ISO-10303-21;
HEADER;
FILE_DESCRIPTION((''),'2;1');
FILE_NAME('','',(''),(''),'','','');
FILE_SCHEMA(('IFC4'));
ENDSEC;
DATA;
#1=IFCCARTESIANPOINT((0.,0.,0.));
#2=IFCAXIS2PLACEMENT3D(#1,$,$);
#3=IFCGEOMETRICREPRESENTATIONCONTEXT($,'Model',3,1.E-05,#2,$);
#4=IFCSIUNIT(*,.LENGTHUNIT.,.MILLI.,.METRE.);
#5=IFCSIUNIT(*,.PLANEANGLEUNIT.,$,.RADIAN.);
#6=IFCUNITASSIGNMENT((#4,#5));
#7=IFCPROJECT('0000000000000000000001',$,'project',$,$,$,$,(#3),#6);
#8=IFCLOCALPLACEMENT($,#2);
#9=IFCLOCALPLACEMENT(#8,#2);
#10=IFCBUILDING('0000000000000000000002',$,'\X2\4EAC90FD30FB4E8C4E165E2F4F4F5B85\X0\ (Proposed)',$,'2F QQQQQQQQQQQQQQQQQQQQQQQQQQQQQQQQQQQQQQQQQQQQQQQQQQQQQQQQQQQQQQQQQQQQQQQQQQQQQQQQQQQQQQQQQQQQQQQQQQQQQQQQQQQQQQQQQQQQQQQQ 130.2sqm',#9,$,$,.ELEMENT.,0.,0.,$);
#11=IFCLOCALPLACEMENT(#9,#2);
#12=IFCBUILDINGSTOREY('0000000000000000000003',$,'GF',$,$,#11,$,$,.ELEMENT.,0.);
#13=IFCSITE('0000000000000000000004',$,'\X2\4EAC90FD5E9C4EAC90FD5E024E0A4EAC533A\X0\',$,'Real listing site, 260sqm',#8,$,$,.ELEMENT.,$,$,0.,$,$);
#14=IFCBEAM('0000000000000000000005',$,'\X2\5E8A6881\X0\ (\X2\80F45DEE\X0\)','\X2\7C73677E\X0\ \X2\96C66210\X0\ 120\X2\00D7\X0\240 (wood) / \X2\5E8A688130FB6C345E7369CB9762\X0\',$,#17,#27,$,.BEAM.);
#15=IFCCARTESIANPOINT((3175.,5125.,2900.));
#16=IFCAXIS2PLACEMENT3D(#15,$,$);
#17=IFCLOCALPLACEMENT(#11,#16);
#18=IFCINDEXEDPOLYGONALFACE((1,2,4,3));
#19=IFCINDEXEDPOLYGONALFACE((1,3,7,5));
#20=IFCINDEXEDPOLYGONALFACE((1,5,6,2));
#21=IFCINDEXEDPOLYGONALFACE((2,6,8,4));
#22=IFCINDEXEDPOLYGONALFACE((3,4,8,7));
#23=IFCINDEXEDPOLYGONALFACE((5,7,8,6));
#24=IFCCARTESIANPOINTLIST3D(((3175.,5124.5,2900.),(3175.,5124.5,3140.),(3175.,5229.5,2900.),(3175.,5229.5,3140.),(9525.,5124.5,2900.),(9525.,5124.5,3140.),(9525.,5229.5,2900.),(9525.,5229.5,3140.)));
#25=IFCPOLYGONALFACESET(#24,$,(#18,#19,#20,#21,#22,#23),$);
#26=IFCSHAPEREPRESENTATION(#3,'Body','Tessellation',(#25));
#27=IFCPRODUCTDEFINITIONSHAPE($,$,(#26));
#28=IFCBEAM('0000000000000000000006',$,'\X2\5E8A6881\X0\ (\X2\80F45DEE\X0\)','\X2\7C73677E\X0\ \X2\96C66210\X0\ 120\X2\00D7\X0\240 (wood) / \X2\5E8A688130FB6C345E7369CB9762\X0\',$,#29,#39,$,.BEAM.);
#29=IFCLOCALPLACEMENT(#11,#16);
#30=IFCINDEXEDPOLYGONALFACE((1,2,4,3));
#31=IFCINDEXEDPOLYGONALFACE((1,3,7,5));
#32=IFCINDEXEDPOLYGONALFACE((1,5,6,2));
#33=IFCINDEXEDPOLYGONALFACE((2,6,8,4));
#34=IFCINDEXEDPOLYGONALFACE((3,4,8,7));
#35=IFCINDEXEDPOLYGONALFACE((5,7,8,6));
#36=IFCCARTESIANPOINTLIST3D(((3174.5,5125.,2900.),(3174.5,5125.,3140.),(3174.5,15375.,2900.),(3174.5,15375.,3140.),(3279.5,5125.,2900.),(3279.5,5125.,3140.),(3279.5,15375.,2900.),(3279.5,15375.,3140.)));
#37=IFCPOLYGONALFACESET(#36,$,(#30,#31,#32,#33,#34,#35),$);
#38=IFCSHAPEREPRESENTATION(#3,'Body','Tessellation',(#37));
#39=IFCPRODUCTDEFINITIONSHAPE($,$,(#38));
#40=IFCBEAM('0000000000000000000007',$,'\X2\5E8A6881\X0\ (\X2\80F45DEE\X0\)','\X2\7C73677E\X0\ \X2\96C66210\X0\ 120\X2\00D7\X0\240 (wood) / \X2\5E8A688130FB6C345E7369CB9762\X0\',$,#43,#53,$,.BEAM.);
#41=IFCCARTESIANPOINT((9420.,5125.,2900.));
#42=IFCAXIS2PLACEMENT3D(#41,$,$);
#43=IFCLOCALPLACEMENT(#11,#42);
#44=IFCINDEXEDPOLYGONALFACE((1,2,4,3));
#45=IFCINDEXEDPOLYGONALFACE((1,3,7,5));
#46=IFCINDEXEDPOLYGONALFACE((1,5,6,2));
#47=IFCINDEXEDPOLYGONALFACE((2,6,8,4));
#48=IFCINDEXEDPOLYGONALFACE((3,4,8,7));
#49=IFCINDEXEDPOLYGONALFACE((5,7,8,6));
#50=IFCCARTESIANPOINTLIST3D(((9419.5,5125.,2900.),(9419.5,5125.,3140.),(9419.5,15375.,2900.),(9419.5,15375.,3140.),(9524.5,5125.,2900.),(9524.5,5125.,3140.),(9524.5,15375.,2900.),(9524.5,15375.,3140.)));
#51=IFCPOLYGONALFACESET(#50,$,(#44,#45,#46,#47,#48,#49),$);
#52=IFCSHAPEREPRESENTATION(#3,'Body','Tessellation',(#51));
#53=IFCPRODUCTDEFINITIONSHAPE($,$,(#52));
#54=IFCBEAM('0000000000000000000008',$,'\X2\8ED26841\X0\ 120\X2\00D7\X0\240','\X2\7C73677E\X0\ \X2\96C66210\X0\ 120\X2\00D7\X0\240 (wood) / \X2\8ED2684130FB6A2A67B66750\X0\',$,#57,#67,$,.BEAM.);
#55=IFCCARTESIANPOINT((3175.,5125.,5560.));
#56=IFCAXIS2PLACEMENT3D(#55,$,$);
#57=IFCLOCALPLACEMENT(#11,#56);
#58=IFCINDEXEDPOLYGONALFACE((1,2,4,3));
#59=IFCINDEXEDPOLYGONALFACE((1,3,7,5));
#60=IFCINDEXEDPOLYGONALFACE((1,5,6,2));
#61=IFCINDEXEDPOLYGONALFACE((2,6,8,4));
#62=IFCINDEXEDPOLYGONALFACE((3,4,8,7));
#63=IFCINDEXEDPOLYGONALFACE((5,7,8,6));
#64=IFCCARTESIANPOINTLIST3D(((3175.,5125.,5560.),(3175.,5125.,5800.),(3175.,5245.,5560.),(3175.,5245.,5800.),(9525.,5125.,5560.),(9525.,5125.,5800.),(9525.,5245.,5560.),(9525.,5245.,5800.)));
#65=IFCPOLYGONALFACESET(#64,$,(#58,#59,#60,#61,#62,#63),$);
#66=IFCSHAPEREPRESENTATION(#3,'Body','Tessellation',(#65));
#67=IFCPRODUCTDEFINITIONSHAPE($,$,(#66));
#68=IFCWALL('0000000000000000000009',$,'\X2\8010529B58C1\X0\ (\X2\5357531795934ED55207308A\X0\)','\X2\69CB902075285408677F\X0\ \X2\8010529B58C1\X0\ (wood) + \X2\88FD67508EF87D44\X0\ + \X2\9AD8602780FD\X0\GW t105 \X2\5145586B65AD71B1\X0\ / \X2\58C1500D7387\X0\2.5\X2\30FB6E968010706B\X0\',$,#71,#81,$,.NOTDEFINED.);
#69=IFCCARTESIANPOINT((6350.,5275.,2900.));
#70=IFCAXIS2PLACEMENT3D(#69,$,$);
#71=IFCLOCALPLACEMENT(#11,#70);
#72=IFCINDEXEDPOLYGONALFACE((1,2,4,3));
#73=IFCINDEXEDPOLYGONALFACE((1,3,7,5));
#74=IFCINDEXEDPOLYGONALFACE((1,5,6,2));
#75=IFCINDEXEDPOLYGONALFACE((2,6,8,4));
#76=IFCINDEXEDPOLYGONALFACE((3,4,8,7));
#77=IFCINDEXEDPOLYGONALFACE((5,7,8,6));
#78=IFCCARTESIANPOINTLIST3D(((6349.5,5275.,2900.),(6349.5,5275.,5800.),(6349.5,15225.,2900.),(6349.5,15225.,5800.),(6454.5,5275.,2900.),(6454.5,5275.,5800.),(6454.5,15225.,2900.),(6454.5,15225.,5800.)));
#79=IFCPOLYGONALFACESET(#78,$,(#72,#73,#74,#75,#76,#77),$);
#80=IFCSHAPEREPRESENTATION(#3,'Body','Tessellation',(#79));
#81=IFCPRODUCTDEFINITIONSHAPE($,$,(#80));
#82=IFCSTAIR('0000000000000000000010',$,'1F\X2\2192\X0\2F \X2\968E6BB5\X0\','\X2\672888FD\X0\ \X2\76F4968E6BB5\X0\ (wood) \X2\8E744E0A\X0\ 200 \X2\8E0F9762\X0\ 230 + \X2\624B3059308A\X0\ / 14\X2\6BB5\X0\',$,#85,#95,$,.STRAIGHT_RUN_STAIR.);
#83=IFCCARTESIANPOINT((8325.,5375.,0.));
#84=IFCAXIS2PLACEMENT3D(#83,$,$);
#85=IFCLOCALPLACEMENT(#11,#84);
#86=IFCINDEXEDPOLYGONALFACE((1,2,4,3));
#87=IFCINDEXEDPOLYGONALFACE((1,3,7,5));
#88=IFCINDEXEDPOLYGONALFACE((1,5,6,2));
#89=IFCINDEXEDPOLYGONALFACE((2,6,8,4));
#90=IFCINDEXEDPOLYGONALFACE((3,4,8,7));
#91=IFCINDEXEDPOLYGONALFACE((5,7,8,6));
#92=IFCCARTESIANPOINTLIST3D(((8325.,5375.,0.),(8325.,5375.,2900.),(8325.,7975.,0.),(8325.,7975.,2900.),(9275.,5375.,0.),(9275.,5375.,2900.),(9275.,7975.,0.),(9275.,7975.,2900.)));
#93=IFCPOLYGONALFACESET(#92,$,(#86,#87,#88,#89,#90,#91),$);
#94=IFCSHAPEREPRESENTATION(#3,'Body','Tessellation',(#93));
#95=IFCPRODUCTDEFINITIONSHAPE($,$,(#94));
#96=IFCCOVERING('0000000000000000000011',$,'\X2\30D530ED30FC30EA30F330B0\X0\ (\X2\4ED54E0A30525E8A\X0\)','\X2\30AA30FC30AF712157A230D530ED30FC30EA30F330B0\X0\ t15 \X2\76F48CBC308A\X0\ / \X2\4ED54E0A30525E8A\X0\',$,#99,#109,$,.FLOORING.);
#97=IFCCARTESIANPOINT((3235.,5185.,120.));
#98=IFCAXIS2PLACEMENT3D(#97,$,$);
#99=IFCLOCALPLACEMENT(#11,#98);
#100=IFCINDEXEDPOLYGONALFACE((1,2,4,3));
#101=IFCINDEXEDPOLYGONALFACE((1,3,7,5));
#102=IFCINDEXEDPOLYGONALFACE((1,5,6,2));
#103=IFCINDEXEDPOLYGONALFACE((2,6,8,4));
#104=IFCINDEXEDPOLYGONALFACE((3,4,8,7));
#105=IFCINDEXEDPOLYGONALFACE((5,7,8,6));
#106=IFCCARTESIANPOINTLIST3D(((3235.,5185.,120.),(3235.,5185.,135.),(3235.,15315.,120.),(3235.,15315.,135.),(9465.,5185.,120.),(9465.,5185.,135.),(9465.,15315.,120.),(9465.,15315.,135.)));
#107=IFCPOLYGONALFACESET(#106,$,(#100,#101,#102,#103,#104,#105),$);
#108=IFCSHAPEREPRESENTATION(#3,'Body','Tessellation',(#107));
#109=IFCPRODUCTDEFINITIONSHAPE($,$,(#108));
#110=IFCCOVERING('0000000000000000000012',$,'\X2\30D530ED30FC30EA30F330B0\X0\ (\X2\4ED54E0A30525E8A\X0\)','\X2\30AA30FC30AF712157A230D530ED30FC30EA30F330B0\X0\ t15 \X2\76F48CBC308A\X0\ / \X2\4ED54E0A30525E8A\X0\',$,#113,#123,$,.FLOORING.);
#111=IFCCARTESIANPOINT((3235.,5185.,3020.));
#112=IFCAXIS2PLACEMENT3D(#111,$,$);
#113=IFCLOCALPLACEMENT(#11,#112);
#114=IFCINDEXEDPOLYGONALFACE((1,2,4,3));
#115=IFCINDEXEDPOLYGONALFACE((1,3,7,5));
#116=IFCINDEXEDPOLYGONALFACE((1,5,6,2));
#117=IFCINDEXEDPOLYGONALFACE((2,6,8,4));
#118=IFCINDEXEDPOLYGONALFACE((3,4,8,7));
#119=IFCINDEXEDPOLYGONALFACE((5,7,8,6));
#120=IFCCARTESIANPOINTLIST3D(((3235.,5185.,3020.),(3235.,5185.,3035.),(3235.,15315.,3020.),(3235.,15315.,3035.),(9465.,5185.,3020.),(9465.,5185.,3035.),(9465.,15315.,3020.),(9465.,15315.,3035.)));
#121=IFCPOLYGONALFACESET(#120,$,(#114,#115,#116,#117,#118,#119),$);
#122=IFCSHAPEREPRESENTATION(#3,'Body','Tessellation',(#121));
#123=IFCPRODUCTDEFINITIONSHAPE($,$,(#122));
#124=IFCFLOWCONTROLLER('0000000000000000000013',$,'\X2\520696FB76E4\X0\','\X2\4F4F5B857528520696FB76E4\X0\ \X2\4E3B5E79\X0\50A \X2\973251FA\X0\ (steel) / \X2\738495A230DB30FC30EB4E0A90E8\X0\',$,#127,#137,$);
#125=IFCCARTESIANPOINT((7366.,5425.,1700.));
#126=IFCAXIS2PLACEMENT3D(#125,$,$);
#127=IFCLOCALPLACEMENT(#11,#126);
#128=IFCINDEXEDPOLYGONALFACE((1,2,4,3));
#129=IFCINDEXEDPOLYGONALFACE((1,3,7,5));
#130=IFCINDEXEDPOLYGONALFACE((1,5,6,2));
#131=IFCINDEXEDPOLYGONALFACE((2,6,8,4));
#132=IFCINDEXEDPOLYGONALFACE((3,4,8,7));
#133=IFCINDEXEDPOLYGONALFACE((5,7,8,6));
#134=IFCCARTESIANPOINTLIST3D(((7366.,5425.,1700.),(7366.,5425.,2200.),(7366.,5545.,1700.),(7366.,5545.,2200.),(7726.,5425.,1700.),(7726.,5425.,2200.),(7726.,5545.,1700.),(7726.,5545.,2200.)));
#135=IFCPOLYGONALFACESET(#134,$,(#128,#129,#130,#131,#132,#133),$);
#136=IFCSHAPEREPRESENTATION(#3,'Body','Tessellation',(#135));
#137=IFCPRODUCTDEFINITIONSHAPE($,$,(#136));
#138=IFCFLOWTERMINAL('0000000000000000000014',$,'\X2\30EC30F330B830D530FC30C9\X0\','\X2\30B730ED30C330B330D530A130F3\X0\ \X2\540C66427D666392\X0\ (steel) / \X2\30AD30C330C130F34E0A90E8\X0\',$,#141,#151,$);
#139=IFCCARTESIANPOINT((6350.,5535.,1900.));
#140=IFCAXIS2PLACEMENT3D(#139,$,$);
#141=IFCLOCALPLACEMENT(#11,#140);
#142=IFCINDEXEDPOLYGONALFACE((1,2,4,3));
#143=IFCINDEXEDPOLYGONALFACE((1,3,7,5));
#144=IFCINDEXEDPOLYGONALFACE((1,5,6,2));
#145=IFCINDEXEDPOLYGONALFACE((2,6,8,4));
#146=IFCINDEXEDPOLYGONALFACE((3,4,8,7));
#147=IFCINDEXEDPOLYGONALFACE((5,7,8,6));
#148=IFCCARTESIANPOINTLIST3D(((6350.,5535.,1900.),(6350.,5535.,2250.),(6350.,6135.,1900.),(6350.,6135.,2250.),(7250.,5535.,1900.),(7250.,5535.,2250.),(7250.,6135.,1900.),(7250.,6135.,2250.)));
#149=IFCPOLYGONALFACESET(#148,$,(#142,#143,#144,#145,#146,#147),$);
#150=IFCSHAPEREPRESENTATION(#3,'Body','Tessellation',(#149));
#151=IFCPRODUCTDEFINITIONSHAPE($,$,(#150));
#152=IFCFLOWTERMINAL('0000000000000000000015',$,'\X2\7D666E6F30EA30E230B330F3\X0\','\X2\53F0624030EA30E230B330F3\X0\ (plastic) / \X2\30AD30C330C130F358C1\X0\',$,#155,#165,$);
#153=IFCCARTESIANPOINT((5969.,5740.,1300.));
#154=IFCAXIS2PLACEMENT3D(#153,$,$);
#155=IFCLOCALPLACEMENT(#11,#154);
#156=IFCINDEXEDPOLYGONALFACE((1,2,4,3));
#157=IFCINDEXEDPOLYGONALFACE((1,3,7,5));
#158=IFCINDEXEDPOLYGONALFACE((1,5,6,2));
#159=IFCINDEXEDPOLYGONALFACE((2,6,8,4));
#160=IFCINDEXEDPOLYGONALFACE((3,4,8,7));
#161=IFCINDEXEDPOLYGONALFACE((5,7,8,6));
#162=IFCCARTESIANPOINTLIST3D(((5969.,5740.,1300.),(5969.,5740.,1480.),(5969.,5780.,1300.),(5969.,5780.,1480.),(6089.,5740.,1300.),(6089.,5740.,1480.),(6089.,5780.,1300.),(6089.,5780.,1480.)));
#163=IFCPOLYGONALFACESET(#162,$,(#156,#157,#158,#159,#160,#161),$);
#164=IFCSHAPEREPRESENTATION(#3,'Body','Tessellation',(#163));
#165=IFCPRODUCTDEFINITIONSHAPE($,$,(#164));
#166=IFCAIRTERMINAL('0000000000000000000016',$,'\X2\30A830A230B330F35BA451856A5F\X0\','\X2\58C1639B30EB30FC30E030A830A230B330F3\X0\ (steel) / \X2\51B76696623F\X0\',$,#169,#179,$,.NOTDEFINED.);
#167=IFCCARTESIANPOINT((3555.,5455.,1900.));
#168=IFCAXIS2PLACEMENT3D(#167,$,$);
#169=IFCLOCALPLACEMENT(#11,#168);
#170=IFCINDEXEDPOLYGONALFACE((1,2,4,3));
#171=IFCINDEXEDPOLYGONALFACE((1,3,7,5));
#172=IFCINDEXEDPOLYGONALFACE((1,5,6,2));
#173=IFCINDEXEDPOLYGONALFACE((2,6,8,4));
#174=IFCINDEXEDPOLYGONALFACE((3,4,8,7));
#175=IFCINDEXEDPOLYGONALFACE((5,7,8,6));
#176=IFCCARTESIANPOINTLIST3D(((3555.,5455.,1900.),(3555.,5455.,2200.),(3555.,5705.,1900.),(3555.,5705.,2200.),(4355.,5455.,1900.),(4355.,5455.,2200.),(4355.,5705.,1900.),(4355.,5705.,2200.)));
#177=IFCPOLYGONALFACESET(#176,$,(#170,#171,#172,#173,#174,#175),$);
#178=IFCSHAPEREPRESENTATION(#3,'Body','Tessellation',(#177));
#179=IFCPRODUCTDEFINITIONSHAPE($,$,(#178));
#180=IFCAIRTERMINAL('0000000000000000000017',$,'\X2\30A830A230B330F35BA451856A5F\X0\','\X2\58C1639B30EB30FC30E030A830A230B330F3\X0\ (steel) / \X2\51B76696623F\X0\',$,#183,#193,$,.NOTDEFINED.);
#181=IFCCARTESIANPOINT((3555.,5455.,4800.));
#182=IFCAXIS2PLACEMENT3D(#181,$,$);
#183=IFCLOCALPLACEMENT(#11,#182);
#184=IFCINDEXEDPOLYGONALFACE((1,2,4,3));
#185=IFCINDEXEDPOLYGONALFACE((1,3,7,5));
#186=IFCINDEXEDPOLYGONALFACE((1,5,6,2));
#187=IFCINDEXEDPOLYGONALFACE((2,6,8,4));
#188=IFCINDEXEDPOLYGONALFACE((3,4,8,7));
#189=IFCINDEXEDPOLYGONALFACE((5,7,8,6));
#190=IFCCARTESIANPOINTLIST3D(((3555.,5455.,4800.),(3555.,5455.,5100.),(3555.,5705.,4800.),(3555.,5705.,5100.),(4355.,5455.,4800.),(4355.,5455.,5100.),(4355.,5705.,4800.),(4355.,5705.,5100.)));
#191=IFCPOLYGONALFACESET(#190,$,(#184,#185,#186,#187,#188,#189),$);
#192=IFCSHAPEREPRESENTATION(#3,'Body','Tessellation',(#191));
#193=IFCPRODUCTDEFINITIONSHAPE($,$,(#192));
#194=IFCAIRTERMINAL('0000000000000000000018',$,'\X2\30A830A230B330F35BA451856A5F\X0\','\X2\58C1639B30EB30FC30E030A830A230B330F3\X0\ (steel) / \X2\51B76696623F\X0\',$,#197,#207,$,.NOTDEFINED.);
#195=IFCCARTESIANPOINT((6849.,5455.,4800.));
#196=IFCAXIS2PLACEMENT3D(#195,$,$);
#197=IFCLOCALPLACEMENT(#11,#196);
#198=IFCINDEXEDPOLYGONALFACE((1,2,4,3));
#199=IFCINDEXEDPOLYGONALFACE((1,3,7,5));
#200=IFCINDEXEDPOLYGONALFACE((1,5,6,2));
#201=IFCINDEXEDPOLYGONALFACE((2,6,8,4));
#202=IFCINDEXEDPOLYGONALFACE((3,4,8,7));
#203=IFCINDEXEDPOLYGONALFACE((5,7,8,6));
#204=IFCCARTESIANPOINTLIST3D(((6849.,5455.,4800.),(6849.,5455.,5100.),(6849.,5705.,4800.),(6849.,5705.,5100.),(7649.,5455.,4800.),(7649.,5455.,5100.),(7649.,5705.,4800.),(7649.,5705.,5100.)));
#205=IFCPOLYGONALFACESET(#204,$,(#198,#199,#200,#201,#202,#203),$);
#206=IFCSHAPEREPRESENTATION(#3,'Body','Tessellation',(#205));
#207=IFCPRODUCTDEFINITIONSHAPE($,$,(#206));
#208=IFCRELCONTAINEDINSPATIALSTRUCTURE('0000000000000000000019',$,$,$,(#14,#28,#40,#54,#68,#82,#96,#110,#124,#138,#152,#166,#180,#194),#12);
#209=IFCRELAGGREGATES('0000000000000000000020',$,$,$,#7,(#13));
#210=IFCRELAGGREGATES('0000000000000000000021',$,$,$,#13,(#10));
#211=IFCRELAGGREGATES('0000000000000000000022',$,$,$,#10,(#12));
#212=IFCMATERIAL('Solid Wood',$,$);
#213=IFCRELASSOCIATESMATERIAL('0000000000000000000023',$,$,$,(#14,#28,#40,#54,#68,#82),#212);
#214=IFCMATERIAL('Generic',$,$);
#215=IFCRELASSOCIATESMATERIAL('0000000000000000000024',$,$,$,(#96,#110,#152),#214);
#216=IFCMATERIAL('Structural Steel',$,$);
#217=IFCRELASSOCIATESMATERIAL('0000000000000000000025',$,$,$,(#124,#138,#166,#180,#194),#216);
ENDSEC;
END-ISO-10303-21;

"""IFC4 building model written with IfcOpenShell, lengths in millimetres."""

from ifc_helpers import new_model, si_unit, frame, frame_2d, origin, place, context, project, spatial, rectangle, extrude, material, element, save


model = new_model("IFC4")

# Units and contexts
model_context = context("Model", 3, precision=1e-05, world=origin())
ifc_project = project(units=[si_unit("LENGTHUNIT", "METRE", prefix="MILLI"), si_unit("PLANEANGLEUNIT", "RADIAN")], contexts=[model_context])

# Site, building, storey
site_placement = place(None, origin())
site = spatial("IfcSite", under=ifc_project, at=site_placement, Name="京都府京都市上京区", ObjectType="Real listing site, 260sqm", CompositionType="ELEMENT", RefElevation=0.0)
building_placement = place(site_placement, origin())
building = spatial("IfcBuilding", under=site, at=building_placement, Name="京都・二世帯住宅 (Proposed)", ObjectType="2F QQQQQQQQQQQQQQQQQQQQQQQQQQQQQQQQQQQQQQQQQQQQQQQQQQQQQQQQQQQQQQQQQQQQQQQQQQQQQQQQQQQQQQQQQQQQQQQQQQQQQQQQQQQQQQQQQQQQQQQQ 130.2sqm", CompositionType="ELEMENT", ElevationOfRefHeight=0.0, ElevationOfTerrain=0.0)
storey_placement = place(building_placement, origin())
storey = spatial("IfcBuildingStorey", under=building, at=storey_placement, Name="GF", CompositionType="ELEMENT", Elevation=0.0)

# Shared definitions
ifc_material_1 = material(Name="Solid Wood")

# Beams
beam_1_placement = place(storey_placement, frame((3175.0, 5125.0, 2900.0)))
element("IfcBeam", 1, at=beam_1_placement, inside=storey, material=ifc_material_1, Name="床梁 (胴差)", Description="米松 集成 120×240 (wood) / 床梁・水平構面", PredefinedType="BEAM", context=model_context, shape_type="SweptSolid", body=[
    extrude(rectangle(XDim=6350.0, YDim=105.0, at=frame_2d((3175.0, 52.0))), frame((3175.0, 5125.0, 2900.0)), (0.0, 0.0, 1.0), 240.0),
])
beam_2_placement = place(storey_placement, frame((3175.0, 5125.0, 2900.0)))
element("IfcBeam", 2, at=beam_2_placement, inside=storey, material=ifc_material_1, Name="床梁 (胴差)", Description="米松 集成 120×240 (wood) / 床梁・水平構面", PredefinedType="BEAM", context=model_context, shape_type="SweptSolid", body=[
    extrude(rectangle(XDim=105.0, YDim=10250.0, at=frame_2d((52.0, 5125.0))), frame((3175.0, 5125.0, 2900.0)), (0.0, 0.0, 1.0), 240.0),
])
beam_3_placement = place(storey_placement, frame((9420.0, 5125.0, 2900.0)))
element("IfcBeam", 3, at=beam_3_placement, inside=storey, material=ifc_material_1, Name="床梁 (胴差)", Description="米松 集成 120×240 (wood) / 床梁・水平構面", PredefinedType="BEAM", context=model_context, shape_type="SweptSolid", body=[
    extrude(rectangle(XDim=105.0, YDim=10250.0, at=frame_2d((52.0, 5125.0))), frame((9420.0, 5125.0, 2900.0)), (0.0, 0.0, 1.0), 240.0),
])
beam_4_placement = place(storey_placement, frame((3175.0, 5125.0, 5560.0)))
element("IfcBeam", 4, at=beam_4_placement, inside=storey, material=ifc_material_1, Name="軒桁 120×240", Description="米松 集成 120×240 (wood) / 軒桁・横架材", PredefinedType="BEAM", context=model_context, shape_type="SweptSolid", body=[
    extrude(rectangle(XDim=6350.0, YDim=120.0, at=frame_2d((3175.0, 60.0))), frame((3175.0, 5125.0, 5560.0)), (0.0, 0.0, 1.0), 240.0),
])

# Wall
wall_1_placement = place(storey_placement, frame((6350.0, 5275.0, 2900.0)))
element("IfcWall", 5, at=wall_1_placement, inside=storey, material=ifc_material_1, Name="耐力壁 (南北間仕切り)", Description="構造用合板 耐力壁 (wood) + 製材軸組 + 高性能GW t105 充填断熱 / 壁倍率2.5・準耐火", PredefinedType="NOTDEFINED", context=model_context, shape_type="SweptSolid", body=[
    extrude(rectangle(XDim=105.0, YDim=9950.0, at=frame_2d((52.0, 4975.0))), frame((6350.0, 5275.0, 2900.0)), (0.0, 0.0, 1.0), 2900.0),
])

# Stair
stair_placement = place(storey_placement, frame((8325.0, 5375.0, 0.0)))
element("IfcStair", 6, at=stair_placement, inside=storey, material=ifc_material_1, Name="1F→2F 階段", Description="木製 直階段 (wood) 蹴上 200 踏面 230 + 手すり / 14段", PredefinedType="STRAIGHT_RUN_STAIR", context=model_context, shape_type="SweptSolid", body=[
    extrude(rectangle(XDim=950.0, YDim=2600.0, at=frame_2d((475.0, 1300.0))), frame((8325.0, 5375.0, 0.0)), (0.0, 0.0, 1.0), 2900.0),
])

# Coverings
ifc_material_2 = material(Name="Generic")
covering_1_placement = place(storey_placement, frame((3235.0, 5185.0, 120.0)))
element("IfcCovering", 7, at=covering_1_placement, inside=storey, material=ifc_material_2, Name="フローリング (仕上げ床)", Description="オーク無垢フローリング t15 直貼り / 仕上げ床", PredefinedType="FLOORING", context=model_context, shape_type="SweptSolid", body=[
    extrude(rectangle(XDim=6230.0, YDim=10130.0, at=frame_2d((3115.0, 5065.0))), frame((3235.0, 5185.0, 120.0)), (0.0, 0.0, 1.0), 15.0),
])
covering_2_placement = place(storey_placement, frame((3235.0, 5185.0, 3020.0)))
element("IfcCovering", 8, at=covering_2_placement, inside=storey, material=ifc_material_2, Name="フローリング (仕上げ床)", Description="オーク無垢フローリング t15 直貼り / 仕上げ床", PredefinedType="FLOORING", context=model_context, shape_type="SweptSolid", body=[
    extrude(rectangle(XDim=6230.0, YDim=10130.0, at=frame_2d((3115.0, 5065.0))), frame((3235.0, 5185.0, 3020.0)), (0.0, 0.0, 1.0), 15.0),
])

# Flow controller
ifc_material_3 = material(Name="Structural Steel")
flow_controller_placement = place(storey_placement, frame((7366.0, 5425.0, 1700.0)))
element("IfcFlowController", 9, at=flow_controller_placement, inside=storey, material=ifc_material_3, Name="分電盤", Description="住宅用分電盤 主幹50A 露出 (steel) / 玄関ホール上部", context=model_context, shape_type="SweptSolid", body=[
    extrude(rectangle(XDim=360.0, YDim=120.0, at=frame_2d((180.0, 60.0))), frame((7366.0, 5425.0, 1700.0)), (0.0, 0.0, 1.0), 500.0),
])

# Flow terminals
flow_terminal_1_placement = place(storey_placement, frame((6350.0, 5535.0, 1900.0)))
element("IfcFlowTerminal", 10, at=flow_terminal_1_placement, inside=storey, material=ifc_material_3, Name="レンジフード", Description="シロッコファン 同時給排 (steel) / キッチン上部", context=model_context, shape_type="SweptSolid", body=[
    extrude(rectangle(XDim=900.0, YDim=600.0, at=frame_2d((450.0, 300.0))), frame((6350.0, 5535.0, 1900.0)), (0.0, 0.0, 1.0), 350.0),
])
flow_terminal_2_placement = place(storey_placement, frame((5969.0, 5740.0, 1300.0)))
element("IfcFlowTerminal", 11, at=flow_terminal_2_placement, inside=storey, material=ifc_material_2, Name="給湯リモコン", Description="台所リモコン (plastic) / キッチン壁", context=model_context, shape_type="SweptSolid", body=[
    extrude(rectangle(XDim=120.0, YDim=40.0, at=frame_2d((60.0, 20.0))), frame((5969.0, 5740.0, 1300.0)), (0.0, 0.0, 1.0), 180.0),
])

# Air terminals
air_terminal_1_placement = place(storey_placement, frame((3555.0, 5455.0, 1900.0)))
element("IfcAirTerminal", 12, at=air_terminal_1_placement, inside=storey, material=ifc_material_3, Name="エアコン室内機", Description="壁掛ルームエアコン (steel) / 冷暖房", PredefinedType="NOTDEFINED", context=model_context, shape_type="SweptSolid", body=[
    extrude(rectangle(XDim=800.0, YDim=250.0, at=frame_2d((400.0, 125.0))), frame((3555.0, 5455.0, 1900.0)), (0.0, 0.0, 1.0), 300.0),
])
air_terminal_2_placement = place(storey_placement, frame((3555.0, 5455.0, 4800.0)))
element("IfcAirTerminal", 13, at=air_terminal_2_placement, inside=storey, material=ifc_material_3, Name="エアコン室内機", Description="壁掛ルームエアコン (steel) / 冷暖房", PredefinedType="NOTDEFINED", context=model_context, shape_type="SweptSolid", body=[
    extrude(rectangle(XDim=800.0, YDim=250.0, at=frame_2d((400.0, 125.0))), frame((3555.0, 5455.0, 4800.0)), (0.0, 0.0, 1.0), 300.0),
])
air_terminal_3_placement = place(storey_placement, frame((6849.0, 5455.0, 4800.0)))
element("IfcAirTerminal", 14, at=air_terminal_3_placement, inside=storey, material=ifc_material_3, Name="エアコン室内機", Description="壁掛ルームエアコン (steel) / 冷暖房", PredefinedType="NOTDEFINED", context=model_context, shape_type="SweptSolid", body=[
    extrude(rectangle(XDim=800.0, YDim=250.0, at=frame_2d((400.0, 125.0))), frame((6849.0, 5455.0, 4800.0)), (0.0, 0.0, 1.0), 300.0),
])

save(model, "model.ifc")
